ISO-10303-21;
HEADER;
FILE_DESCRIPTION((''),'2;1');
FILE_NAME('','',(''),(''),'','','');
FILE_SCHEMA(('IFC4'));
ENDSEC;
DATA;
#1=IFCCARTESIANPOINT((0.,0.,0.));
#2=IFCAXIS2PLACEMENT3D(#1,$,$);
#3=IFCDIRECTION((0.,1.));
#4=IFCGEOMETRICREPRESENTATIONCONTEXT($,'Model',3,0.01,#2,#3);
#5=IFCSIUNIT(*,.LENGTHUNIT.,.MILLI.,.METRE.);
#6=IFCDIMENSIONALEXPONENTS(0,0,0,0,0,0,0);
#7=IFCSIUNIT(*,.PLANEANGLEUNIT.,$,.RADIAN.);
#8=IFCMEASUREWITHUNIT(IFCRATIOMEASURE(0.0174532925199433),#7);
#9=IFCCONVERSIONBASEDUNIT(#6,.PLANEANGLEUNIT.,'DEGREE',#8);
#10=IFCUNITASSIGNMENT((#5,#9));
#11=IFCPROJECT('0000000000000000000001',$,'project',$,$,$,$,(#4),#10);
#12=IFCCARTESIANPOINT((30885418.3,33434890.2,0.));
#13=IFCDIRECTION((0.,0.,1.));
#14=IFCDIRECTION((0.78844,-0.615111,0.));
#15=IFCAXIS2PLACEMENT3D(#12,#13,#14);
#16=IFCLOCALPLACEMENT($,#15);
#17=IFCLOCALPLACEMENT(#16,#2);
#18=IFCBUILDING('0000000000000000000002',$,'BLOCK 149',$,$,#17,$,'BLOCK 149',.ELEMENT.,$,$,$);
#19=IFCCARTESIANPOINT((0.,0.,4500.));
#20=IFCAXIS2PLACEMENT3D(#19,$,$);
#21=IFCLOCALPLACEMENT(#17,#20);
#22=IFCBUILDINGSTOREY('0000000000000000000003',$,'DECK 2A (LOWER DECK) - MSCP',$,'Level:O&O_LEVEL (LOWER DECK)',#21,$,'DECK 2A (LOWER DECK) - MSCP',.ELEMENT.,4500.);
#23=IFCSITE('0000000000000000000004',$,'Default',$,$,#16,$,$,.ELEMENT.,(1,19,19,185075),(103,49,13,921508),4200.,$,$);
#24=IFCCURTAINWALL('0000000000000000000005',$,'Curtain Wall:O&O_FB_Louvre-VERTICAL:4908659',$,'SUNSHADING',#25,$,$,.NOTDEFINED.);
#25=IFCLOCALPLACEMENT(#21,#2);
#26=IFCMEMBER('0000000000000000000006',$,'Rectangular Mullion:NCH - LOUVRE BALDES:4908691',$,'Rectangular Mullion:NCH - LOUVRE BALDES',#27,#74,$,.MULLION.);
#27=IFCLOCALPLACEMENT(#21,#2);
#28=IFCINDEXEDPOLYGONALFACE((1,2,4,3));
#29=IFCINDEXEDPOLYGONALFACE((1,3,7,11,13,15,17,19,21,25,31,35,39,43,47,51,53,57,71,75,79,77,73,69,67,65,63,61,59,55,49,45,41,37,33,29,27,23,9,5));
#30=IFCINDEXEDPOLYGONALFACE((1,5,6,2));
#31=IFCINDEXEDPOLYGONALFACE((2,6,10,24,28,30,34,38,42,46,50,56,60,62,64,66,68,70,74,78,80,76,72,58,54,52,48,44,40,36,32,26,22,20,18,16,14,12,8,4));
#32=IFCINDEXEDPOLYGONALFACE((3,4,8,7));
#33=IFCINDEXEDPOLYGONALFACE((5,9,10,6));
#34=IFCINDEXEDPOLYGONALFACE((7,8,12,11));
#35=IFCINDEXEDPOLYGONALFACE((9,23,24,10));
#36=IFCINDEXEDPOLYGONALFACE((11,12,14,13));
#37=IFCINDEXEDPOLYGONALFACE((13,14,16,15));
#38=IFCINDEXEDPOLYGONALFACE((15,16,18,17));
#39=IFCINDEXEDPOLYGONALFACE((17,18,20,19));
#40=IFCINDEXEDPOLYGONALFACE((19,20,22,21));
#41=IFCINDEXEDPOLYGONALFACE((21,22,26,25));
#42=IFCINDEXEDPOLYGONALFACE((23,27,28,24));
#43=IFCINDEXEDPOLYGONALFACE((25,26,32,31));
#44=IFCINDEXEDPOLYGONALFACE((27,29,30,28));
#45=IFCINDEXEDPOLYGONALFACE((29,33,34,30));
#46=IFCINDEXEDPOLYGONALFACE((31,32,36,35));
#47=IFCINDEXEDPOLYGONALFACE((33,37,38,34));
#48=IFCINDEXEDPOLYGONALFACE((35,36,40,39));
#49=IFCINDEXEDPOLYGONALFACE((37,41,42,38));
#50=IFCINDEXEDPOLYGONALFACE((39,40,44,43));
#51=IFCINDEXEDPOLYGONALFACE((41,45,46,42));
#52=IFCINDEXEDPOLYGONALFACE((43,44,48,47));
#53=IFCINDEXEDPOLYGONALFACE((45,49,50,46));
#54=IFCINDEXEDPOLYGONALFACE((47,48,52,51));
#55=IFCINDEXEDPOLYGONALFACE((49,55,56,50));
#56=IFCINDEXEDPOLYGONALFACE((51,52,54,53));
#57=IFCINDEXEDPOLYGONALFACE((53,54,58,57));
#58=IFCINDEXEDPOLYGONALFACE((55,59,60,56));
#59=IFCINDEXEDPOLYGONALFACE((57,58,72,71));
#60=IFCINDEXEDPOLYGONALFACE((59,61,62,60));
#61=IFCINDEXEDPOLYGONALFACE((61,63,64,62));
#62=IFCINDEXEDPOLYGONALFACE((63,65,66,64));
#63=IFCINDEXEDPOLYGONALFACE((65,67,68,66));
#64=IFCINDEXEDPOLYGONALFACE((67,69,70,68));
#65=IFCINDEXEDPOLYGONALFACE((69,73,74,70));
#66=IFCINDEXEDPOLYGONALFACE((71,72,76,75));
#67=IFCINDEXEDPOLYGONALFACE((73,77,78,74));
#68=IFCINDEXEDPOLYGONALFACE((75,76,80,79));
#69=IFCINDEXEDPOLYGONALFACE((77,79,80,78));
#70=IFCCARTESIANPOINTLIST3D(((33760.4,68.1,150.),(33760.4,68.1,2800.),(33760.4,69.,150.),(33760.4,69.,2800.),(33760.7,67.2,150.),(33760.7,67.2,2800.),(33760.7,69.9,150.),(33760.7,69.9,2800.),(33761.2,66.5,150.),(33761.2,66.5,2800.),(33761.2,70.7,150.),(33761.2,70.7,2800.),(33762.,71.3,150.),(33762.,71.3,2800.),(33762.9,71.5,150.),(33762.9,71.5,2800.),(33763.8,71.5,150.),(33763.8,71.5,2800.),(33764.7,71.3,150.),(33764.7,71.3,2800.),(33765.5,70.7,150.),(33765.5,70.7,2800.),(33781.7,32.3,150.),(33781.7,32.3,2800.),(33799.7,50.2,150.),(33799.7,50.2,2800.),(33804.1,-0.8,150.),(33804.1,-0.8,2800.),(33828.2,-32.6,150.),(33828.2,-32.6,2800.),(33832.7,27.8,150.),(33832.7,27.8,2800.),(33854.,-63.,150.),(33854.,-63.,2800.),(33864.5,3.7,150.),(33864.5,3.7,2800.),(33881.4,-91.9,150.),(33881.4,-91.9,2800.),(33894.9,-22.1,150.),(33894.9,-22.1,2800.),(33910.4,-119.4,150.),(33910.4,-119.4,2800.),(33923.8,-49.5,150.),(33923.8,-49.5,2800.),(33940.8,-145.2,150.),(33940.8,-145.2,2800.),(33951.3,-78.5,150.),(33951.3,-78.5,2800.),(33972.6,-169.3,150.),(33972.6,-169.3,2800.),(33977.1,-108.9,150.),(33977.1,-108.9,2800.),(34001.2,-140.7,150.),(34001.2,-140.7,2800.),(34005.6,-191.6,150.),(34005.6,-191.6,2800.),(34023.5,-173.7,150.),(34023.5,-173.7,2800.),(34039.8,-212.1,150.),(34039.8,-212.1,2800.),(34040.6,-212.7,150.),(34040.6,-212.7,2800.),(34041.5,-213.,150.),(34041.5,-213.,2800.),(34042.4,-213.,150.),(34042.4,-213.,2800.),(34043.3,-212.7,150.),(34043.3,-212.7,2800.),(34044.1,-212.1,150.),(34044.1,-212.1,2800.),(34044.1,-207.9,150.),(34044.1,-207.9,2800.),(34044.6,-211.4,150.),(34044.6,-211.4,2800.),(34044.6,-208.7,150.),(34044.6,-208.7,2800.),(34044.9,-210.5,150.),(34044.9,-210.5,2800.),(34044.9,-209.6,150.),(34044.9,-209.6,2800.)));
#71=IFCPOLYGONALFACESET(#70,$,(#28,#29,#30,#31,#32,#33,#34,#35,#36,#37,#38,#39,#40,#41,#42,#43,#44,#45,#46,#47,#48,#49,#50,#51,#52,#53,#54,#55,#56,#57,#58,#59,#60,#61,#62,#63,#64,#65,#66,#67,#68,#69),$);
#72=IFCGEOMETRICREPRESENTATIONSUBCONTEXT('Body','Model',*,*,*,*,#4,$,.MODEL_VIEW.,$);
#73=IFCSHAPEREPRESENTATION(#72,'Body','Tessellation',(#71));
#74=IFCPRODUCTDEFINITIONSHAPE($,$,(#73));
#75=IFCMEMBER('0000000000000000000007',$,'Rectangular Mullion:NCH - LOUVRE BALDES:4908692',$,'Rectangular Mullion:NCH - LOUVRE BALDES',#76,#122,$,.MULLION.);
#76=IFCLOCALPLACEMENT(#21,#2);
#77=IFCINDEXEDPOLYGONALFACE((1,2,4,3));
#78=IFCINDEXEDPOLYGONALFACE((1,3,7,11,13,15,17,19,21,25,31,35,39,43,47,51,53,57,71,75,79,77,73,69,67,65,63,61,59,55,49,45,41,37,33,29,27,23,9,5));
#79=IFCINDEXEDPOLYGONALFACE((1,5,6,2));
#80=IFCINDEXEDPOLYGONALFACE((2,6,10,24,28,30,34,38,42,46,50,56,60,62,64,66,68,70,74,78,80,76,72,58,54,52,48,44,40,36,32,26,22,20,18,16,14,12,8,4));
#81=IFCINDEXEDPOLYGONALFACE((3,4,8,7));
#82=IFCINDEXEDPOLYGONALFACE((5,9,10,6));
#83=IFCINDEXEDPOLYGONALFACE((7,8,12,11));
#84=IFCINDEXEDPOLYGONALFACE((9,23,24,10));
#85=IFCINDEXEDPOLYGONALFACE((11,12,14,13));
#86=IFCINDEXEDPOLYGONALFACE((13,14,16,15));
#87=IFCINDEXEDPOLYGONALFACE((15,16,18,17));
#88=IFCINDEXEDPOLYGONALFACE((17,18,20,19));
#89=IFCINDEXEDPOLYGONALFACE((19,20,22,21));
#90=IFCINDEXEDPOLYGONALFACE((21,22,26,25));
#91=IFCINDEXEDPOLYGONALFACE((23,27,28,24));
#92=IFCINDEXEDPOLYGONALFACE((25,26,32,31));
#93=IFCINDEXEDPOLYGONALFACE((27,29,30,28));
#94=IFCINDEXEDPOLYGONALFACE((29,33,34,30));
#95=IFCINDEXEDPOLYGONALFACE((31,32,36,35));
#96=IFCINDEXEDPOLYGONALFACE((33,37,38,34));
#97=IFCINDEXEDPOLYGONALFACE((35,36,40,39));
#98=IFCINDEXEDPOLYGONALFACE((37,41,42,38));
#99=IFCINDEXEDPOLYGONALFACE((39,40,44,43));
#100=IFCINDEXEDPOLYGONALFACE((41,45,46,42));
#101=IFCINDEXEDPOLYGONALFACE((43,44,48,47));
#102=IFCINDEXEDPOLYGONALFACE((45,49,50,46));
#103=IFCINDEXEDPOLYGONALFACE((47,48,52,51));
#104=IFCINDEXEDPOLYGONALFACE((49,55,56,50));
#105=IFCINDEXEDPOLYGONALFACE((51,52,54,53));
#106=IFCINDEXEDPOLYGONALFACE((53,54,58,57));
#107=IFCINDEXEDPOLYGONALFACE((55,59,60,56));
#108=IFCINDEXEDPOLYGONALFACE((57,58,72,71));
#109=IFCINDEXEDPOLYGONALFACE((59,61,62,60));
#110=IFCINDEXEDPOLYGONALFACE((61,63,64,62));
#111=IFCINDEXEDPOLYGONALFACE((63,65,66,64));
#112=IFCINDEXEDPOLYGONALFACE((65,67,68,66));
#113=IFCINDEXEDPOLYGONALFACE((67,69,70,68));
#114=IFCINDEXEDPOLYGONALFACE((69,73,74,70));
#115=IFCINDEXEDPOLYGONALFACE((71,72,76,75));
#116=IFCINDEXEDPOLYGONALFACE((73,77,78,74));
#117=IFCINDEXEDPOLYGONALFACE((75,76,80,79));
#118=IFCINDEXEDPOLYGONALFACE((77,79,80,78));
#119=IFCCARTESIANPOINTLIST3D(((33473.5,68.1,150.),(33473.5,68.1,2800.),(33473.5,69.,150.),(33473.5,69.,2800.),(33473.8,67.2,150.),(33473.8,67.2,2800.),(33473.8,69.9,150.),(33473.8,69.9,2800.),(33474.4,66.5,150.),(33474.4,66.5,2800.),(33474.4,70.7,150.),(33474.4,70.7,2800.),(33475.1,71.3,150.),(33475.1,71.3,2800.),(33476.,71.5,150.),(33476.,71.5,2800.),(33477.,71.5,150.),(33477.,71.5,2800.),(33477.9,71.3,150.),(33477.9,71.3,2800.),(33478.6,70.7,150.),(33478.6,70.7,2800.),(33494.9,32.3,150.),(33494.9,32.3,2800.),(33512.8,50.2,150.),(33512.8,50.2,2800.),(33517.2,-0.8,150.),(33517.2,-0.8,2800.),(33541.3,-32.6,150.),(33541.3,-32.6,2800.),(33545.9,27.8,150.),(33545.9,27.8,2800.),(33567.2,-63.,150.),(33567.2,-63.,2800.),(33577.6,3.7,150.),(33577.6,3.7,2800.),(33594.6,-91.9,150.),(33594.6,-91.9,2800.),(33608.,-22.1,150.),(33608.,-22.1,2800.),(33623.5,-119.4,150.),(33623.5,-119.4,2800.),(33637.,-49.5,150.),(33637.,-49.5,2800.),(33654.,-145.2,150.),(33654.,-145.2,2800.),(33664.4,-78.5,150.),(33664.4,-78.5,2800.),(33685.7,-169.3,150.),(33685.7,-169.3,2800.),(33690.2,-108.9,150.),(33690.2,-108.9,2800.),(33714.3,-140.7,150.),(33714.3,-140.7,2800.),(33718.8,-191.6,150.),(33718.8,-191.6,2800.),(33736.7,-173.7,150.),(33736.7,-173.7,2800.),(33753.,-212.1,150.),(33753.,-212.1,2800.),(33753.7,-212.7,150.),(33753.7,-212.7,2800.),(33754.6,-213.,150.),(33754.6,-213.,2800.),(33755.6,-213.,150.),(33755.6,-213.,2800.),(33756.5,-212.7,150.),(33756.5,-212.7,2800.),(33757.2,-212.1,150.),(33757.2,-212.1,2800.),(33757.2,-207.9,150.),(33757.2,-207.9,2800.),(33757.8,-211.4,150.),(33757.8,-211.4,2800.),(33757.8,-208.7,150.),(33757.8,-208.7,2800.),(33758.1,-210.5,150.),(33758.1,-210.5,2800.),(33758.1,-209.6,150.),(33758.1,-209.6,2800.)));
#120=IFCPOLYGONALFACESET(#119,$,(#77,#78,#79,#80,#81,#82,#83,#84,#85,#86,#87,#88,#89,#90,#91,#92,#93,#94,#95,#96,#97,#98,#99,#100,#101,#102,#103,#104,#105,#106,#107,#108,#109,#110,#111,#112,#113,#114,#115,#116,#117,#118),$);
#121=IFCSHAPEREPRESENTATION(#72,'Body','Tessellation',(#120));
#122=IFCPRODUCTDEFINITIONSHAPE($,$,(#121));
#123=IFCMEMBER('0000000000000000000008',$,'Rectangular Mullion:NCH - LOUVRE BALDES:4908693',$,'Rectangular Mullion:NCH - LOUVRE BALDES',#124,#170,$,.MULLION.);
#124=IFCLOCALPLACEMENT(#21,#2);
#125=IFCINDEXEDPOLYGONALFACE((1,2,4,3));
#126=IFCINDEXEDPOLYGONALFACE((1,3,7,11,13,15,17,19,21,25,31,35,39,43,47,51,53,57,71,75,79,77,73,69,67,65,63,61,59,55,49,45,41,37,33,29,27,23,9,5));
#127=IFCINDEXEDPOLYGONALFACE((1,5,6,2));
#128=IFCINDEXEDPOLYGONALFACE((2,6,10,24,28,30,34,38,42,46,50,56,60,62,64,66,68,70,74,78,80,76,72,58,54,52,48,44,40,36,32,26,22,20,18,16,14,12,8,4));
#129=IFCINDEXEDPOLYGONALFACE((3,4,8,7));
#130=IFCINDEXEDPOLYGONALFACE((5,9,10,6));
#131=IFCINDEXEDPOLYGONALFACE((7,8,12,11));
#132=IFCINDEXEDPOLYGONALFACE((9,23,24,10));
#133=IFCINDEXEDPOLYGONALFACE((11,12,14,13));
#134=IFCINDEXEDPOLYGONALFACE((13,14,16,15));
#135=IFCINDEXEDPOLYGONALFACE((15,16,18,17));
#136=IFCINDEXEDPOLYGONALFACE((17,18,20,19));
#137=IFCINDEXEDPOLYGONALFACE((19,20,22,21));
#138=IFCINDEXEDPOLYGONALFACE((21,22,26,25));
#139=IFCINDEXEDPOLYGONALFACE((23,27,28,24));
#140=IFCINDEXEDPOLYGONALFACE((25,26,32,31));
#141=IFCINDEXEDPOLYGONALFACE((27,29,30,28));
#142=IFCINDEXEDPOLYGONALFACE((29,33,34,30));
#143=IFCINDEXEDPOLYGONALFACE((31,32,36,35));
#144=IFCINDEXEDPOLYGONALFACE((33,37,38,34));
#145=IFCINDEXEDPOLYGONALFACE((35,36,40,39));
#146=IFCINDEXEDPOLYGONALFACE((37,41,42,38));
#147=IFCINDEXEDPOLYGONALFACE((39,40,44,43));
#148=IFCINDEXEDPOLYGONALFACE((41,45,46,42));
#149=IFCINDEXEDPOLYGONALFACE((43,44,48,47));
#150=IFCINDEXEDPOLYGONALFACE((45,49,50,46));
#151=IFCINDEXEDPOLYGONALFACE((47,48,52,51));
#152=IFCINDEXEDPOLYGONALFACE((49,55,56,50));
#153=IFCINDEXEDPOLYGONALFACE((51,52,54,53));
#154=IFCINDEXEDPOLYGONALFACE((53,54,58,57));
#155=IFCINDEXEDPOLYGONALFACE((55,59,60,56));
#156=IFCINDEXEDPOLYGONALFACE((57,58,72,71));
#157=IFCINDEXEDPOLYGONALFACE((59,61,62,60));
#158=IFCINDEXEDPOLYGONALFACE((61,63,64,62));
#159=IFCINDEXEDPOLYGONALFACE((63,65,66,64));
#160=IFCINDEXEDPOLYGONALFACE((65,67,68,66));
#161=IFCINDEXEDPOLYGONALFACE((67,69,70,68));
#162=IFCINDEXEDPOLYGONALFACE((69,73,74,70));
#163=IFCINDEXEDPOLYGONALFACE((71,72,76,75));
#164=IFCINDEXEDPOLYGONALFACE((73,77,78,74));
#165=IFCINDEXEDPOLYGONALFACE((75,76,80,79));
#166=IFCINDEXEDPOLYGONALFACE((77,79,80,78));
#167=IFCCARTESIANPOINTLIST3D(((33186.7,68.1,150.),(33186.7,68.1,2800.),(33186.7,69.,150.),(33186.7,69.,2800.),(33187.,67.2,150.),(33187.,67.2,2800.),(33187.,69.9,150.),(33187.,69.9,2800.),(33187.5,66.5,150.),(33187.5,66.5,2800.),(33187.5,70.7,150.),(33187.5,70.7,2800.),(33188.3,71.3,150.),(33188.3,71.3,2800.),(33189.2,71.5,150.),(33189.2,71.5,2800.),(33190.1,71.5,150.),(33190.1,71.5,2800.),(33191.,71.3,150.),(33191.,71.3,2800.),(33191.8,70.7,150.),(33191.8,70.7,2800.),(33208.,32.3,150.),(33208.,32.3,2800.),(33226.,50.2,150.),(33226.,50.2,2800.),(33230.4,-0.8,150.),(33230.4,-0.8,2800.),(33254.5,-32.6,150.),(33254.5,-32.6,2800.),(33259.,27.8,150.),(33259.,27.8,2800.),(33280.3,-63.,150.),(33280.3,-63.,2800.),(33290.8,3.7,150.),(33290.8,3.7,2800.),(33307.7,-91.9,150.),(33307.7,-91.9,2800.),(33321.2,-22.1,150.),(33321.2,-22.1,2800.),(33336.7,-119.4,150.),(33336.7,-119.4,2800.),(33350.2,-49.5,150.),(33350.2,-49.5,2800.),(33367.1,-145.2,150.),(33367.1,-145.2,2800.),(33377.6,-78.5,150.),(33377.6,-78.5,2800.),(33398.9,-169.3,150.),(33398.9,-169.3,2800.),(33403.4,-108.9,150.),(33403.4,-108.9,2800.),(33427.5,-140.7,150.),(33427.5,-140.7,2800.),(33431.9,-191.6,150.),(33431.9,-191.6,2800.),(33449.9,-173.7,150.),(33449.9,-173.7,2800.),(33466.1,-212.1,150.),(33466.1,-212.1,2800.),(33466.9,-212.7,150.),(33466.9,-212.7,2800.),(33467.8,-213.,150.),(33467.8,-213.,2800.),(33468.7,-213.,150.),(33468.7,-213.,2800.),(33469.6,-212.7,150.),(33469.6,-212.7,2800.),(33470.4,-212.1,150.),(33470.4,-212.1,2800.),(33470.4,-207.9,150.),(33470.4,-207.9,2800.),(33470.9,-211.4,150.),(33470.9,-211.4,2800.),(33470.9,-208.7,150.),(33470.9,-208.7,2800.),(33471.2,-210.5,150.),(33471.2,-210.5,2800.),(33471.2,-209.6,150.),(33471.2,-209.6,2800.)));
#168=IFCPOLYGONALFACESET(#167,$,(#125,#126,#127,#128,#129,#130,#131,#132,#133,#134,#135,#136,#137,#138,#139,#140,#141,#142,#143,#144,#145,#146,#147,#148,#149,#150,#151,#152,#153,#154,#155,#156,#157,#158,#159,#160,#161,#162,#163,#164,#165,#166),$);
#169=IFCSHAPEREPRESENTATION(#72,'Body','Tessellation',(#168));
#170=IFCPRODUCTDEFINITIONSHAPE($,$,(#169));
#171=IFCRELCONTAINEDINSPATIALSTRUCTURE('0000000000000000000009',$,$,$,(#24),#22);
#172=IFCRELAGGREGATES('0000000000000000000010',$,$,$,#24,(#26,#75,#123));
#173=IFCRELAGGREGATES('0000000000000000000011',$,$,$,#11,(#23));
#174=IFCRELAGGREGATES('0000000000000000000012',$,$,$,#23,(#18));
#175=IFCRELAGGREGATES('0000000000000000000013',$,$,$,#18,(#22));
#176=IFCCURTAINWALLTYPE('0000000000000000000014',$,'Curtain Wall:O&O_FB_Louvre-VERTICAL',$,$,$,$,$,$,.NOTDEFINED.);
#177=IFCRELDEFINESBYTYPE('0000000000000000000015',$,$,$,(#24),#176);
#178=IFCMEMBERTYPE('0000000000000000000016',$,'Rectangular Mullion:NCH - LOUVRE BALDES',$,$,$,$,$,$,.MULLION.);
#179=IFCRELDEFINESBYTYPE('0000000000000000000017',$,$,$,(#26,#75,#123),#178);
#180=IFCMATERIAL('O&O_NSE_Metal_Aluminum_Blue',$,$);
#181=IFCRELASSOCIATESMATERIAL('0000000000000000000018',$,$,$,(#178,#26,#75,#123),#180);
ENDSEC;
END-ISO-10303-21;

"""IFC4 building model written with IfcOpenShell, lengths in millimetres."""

from ifc_helpers import new_model, entity, si_unit, converted_unit, direction, frame, origin, place, context, subcontext, project, spatial, indexed_curve, outline, extrude, source, transform, mapped, material, type_object, type_shapes, element, aggregate, save


model = new_model("IFC4")

# Units and contexts
model_context = context("Model", 3, precision=0.01, world=origin(), true_north=direction((0.0, 1.0)))
body_context = subcontext(model_context, "Body", "Model", "MODEL_VIEW")
ifc_project = project(units=[si_unit("LENGTHUNIT", "METRE", prefix="MILLI"), converted_unit("PLANEANGLEUNIT", "DEGREE", entity("IfcRatioMeasure", 0.0174532925199433), si_unit("PLANEANGLEUNIT", "RADIAN"), dimensions=[0, 0, 0, 0, 0, 0, 0])], contexts=[model_context])

# Site, building, storey
site_placement = place(None, frame((30885418.3, 33434890.2, 0.0), z_axis=(0.0, 0.0, 1.0), x_axis=(0.78844, -0.615111, 0.0)))
site = spatial("IfcSite", under=ifc_project, at=site_placement, Name="Default", CompositionType="ELEMENT", RefLatitude=(1, 19, 19, 185075), RefLongitude=(103, 49, 13, 921508), RefElevation=4200.0)
building_placement = place(site_placement, origin())
building = spatial("IfcBuilding", under=site, at=building_placement, Name="BLOCK 149", LongName="BLOCK 149", CompositionType="ELEMENT")
storey_placement = place(building_placement, frame((0.0, 0.0, 4500.0)))
storey = spatial("IfcBuildingStorey", under=building, at=storey_placement, Name="DECK 2A (LOWER DECK) - MSCP", ObjectType="Level:O&O_LEVEL (LOWER DECK)", LongName="DECK 2A (LOWER DECK) - MSCP", CompositionType="ELEMENT", Elevation=4500.0)

# Curtain wall, members
curtain_wall_type = type_object("IfcCurtainWallType", Name="Curtain Wall:O&O_FB_Louvre-VERTICAL", PredefinedType="NOTDEFINED")
curtain_wall_placement = place(storey_placement, frame((0.0, 0.0, -4500.0)))
curtain_wall = element("IfcCurtainWall", 1, at=curtain_wall_placement, inside=storey, type_object=curtain_wall_type, Name="Curtain Wall:O&O_FB_Louvre-VERTICAL:4908659", ObjectType="SUNSHADING", PredefinedType="NOTDEFINED")
placement = place(building_placement, origin())
ifc_material_1 = material(Name="O&O_NSE_Metal_Aluminum_Blue")
member_type_1 = type_object("IfcMemberType", Name="Rectangular Mullion:NCH - LOUVRE BALDES", PredefinedType="MULLION", material=ifc_material_1)
shared_shape_1 = source(origin(), body_context, "Body", "SweptSolid", [
    extrude(outline(indexed_curve([(55.9, -188.9), (54.8, -149.1), (51.6, -109.3), (46.1, -69.8), (38.6, -30.6), (28.9, 8.1), (17.1, 46.2), (3.3, 83.6), (-12.6, 120.2), (-30.4, 155.9), (-50.1, 190.5), (-50.5, 191.4), (-51.1, 192.1), (-52.0, 192.5), (-52.9, 192.7), (-53.8, 192.6), (-54.7, 192.2), (-55.4, 191.6), (-55.8, 190.8), (-56.0, 189.9), (-55.9, 188.9), (-54.8, 149.1), (-51.6, 109.3), (-46.1, 69.8), (-38.6, 30.6), (-28.9, -8.1), (-17.1, -46.2), (-3.3, -83.6), (12.6, -120.2), (30.4, -155.9), (50.1, -190.5), (50.5, -191.4), (51.1, -192.1), (52.0, -192.5), (52.9, -192.7), (53.8, -192.6), (54.7, -192.2), (55.4, -191.6), (55.8, -190.8), (56.0, -189.9), (55.9, -188.9)], self_intersect=False)), frame((0.0, 0.0, -2650.0), z_axis=(0.0, 0.0, 1.0), x_axis=(0.490779, -0.871284, 0.0)), (0.0, 0.0, 1.0), 2650.0),
])
type_shapes(member_type_1, [shared_shape_1])
member_1_placement = place(placement, frame((33902.6, -70.7, 4650.0), z_axis=(0.0, 0.0, -1.0), x_axis=(-1.0, 0.0, 0.0)))
member_1 = element("IfcMember", 2, at=member_1_placement, type_object=member_type_1, material=ifc_material_1, Name="Rectangular Mullion:NCH - LOUVRE BALDES:4908691", ObjectType="Rectangular Mullion:NCH - LOUVRE BALDES", PredefinedType="MULLION", context=body_context, shape_type="MappedRepresentation", body=[
    mapped(shared_shape_1, transform((0.0, 0.0, 0.0), scale=1.0)),
])
member_2_placement = place(placement, frame((33615.8, -70.7, 4650.0), z_axis=(0.0, 0.0, -1.0), x_axis=(-1.0, 0.0, 0.0)))
member_2 = element("IfcMember", 3, at=member_2_placement, type_object=member_type_1, material=ifc_material_1, Name="Rectangular Mullion:NCH - LOUVRE BALDES:4908692", ObjectType="Rectangular Mullion:NCH - LOUVRE BALDES", PredefinedType="MULLION", context=body_context, shape_type="MappedRepresentation", body=[
    mapped(shared_shape_1, transform((0.0, 0.0, 0.0), scale=1.0)),
])
member_3_placement = place(placement, frame((33328.9, -70.7, 4650.0), z_axis=(0.0, 0.0, -1.0), x_axis=(-1.0, 0.0, 0.0)))
member_3 = element("IfcMember", 4, at=member_3_placement, type_object=member_type_1, material=ifc_material_1, Name="Rectangular Mullion:NCH - LOUVRE BALDES:4908693", ObjectType="Rectangular Mullion:NCH - LOUVRE BALDES", PredefinedType="MULLION", context=body_context, shape_type="MappedRepresentation", body=[
    mapped(shared_shape_1, transform((0.0, 0.0, 0.0), scale=1.0)),
])
aggregate(curtain_wall, [member_1, member_2, member_3])

save(model, "model.ifc")
